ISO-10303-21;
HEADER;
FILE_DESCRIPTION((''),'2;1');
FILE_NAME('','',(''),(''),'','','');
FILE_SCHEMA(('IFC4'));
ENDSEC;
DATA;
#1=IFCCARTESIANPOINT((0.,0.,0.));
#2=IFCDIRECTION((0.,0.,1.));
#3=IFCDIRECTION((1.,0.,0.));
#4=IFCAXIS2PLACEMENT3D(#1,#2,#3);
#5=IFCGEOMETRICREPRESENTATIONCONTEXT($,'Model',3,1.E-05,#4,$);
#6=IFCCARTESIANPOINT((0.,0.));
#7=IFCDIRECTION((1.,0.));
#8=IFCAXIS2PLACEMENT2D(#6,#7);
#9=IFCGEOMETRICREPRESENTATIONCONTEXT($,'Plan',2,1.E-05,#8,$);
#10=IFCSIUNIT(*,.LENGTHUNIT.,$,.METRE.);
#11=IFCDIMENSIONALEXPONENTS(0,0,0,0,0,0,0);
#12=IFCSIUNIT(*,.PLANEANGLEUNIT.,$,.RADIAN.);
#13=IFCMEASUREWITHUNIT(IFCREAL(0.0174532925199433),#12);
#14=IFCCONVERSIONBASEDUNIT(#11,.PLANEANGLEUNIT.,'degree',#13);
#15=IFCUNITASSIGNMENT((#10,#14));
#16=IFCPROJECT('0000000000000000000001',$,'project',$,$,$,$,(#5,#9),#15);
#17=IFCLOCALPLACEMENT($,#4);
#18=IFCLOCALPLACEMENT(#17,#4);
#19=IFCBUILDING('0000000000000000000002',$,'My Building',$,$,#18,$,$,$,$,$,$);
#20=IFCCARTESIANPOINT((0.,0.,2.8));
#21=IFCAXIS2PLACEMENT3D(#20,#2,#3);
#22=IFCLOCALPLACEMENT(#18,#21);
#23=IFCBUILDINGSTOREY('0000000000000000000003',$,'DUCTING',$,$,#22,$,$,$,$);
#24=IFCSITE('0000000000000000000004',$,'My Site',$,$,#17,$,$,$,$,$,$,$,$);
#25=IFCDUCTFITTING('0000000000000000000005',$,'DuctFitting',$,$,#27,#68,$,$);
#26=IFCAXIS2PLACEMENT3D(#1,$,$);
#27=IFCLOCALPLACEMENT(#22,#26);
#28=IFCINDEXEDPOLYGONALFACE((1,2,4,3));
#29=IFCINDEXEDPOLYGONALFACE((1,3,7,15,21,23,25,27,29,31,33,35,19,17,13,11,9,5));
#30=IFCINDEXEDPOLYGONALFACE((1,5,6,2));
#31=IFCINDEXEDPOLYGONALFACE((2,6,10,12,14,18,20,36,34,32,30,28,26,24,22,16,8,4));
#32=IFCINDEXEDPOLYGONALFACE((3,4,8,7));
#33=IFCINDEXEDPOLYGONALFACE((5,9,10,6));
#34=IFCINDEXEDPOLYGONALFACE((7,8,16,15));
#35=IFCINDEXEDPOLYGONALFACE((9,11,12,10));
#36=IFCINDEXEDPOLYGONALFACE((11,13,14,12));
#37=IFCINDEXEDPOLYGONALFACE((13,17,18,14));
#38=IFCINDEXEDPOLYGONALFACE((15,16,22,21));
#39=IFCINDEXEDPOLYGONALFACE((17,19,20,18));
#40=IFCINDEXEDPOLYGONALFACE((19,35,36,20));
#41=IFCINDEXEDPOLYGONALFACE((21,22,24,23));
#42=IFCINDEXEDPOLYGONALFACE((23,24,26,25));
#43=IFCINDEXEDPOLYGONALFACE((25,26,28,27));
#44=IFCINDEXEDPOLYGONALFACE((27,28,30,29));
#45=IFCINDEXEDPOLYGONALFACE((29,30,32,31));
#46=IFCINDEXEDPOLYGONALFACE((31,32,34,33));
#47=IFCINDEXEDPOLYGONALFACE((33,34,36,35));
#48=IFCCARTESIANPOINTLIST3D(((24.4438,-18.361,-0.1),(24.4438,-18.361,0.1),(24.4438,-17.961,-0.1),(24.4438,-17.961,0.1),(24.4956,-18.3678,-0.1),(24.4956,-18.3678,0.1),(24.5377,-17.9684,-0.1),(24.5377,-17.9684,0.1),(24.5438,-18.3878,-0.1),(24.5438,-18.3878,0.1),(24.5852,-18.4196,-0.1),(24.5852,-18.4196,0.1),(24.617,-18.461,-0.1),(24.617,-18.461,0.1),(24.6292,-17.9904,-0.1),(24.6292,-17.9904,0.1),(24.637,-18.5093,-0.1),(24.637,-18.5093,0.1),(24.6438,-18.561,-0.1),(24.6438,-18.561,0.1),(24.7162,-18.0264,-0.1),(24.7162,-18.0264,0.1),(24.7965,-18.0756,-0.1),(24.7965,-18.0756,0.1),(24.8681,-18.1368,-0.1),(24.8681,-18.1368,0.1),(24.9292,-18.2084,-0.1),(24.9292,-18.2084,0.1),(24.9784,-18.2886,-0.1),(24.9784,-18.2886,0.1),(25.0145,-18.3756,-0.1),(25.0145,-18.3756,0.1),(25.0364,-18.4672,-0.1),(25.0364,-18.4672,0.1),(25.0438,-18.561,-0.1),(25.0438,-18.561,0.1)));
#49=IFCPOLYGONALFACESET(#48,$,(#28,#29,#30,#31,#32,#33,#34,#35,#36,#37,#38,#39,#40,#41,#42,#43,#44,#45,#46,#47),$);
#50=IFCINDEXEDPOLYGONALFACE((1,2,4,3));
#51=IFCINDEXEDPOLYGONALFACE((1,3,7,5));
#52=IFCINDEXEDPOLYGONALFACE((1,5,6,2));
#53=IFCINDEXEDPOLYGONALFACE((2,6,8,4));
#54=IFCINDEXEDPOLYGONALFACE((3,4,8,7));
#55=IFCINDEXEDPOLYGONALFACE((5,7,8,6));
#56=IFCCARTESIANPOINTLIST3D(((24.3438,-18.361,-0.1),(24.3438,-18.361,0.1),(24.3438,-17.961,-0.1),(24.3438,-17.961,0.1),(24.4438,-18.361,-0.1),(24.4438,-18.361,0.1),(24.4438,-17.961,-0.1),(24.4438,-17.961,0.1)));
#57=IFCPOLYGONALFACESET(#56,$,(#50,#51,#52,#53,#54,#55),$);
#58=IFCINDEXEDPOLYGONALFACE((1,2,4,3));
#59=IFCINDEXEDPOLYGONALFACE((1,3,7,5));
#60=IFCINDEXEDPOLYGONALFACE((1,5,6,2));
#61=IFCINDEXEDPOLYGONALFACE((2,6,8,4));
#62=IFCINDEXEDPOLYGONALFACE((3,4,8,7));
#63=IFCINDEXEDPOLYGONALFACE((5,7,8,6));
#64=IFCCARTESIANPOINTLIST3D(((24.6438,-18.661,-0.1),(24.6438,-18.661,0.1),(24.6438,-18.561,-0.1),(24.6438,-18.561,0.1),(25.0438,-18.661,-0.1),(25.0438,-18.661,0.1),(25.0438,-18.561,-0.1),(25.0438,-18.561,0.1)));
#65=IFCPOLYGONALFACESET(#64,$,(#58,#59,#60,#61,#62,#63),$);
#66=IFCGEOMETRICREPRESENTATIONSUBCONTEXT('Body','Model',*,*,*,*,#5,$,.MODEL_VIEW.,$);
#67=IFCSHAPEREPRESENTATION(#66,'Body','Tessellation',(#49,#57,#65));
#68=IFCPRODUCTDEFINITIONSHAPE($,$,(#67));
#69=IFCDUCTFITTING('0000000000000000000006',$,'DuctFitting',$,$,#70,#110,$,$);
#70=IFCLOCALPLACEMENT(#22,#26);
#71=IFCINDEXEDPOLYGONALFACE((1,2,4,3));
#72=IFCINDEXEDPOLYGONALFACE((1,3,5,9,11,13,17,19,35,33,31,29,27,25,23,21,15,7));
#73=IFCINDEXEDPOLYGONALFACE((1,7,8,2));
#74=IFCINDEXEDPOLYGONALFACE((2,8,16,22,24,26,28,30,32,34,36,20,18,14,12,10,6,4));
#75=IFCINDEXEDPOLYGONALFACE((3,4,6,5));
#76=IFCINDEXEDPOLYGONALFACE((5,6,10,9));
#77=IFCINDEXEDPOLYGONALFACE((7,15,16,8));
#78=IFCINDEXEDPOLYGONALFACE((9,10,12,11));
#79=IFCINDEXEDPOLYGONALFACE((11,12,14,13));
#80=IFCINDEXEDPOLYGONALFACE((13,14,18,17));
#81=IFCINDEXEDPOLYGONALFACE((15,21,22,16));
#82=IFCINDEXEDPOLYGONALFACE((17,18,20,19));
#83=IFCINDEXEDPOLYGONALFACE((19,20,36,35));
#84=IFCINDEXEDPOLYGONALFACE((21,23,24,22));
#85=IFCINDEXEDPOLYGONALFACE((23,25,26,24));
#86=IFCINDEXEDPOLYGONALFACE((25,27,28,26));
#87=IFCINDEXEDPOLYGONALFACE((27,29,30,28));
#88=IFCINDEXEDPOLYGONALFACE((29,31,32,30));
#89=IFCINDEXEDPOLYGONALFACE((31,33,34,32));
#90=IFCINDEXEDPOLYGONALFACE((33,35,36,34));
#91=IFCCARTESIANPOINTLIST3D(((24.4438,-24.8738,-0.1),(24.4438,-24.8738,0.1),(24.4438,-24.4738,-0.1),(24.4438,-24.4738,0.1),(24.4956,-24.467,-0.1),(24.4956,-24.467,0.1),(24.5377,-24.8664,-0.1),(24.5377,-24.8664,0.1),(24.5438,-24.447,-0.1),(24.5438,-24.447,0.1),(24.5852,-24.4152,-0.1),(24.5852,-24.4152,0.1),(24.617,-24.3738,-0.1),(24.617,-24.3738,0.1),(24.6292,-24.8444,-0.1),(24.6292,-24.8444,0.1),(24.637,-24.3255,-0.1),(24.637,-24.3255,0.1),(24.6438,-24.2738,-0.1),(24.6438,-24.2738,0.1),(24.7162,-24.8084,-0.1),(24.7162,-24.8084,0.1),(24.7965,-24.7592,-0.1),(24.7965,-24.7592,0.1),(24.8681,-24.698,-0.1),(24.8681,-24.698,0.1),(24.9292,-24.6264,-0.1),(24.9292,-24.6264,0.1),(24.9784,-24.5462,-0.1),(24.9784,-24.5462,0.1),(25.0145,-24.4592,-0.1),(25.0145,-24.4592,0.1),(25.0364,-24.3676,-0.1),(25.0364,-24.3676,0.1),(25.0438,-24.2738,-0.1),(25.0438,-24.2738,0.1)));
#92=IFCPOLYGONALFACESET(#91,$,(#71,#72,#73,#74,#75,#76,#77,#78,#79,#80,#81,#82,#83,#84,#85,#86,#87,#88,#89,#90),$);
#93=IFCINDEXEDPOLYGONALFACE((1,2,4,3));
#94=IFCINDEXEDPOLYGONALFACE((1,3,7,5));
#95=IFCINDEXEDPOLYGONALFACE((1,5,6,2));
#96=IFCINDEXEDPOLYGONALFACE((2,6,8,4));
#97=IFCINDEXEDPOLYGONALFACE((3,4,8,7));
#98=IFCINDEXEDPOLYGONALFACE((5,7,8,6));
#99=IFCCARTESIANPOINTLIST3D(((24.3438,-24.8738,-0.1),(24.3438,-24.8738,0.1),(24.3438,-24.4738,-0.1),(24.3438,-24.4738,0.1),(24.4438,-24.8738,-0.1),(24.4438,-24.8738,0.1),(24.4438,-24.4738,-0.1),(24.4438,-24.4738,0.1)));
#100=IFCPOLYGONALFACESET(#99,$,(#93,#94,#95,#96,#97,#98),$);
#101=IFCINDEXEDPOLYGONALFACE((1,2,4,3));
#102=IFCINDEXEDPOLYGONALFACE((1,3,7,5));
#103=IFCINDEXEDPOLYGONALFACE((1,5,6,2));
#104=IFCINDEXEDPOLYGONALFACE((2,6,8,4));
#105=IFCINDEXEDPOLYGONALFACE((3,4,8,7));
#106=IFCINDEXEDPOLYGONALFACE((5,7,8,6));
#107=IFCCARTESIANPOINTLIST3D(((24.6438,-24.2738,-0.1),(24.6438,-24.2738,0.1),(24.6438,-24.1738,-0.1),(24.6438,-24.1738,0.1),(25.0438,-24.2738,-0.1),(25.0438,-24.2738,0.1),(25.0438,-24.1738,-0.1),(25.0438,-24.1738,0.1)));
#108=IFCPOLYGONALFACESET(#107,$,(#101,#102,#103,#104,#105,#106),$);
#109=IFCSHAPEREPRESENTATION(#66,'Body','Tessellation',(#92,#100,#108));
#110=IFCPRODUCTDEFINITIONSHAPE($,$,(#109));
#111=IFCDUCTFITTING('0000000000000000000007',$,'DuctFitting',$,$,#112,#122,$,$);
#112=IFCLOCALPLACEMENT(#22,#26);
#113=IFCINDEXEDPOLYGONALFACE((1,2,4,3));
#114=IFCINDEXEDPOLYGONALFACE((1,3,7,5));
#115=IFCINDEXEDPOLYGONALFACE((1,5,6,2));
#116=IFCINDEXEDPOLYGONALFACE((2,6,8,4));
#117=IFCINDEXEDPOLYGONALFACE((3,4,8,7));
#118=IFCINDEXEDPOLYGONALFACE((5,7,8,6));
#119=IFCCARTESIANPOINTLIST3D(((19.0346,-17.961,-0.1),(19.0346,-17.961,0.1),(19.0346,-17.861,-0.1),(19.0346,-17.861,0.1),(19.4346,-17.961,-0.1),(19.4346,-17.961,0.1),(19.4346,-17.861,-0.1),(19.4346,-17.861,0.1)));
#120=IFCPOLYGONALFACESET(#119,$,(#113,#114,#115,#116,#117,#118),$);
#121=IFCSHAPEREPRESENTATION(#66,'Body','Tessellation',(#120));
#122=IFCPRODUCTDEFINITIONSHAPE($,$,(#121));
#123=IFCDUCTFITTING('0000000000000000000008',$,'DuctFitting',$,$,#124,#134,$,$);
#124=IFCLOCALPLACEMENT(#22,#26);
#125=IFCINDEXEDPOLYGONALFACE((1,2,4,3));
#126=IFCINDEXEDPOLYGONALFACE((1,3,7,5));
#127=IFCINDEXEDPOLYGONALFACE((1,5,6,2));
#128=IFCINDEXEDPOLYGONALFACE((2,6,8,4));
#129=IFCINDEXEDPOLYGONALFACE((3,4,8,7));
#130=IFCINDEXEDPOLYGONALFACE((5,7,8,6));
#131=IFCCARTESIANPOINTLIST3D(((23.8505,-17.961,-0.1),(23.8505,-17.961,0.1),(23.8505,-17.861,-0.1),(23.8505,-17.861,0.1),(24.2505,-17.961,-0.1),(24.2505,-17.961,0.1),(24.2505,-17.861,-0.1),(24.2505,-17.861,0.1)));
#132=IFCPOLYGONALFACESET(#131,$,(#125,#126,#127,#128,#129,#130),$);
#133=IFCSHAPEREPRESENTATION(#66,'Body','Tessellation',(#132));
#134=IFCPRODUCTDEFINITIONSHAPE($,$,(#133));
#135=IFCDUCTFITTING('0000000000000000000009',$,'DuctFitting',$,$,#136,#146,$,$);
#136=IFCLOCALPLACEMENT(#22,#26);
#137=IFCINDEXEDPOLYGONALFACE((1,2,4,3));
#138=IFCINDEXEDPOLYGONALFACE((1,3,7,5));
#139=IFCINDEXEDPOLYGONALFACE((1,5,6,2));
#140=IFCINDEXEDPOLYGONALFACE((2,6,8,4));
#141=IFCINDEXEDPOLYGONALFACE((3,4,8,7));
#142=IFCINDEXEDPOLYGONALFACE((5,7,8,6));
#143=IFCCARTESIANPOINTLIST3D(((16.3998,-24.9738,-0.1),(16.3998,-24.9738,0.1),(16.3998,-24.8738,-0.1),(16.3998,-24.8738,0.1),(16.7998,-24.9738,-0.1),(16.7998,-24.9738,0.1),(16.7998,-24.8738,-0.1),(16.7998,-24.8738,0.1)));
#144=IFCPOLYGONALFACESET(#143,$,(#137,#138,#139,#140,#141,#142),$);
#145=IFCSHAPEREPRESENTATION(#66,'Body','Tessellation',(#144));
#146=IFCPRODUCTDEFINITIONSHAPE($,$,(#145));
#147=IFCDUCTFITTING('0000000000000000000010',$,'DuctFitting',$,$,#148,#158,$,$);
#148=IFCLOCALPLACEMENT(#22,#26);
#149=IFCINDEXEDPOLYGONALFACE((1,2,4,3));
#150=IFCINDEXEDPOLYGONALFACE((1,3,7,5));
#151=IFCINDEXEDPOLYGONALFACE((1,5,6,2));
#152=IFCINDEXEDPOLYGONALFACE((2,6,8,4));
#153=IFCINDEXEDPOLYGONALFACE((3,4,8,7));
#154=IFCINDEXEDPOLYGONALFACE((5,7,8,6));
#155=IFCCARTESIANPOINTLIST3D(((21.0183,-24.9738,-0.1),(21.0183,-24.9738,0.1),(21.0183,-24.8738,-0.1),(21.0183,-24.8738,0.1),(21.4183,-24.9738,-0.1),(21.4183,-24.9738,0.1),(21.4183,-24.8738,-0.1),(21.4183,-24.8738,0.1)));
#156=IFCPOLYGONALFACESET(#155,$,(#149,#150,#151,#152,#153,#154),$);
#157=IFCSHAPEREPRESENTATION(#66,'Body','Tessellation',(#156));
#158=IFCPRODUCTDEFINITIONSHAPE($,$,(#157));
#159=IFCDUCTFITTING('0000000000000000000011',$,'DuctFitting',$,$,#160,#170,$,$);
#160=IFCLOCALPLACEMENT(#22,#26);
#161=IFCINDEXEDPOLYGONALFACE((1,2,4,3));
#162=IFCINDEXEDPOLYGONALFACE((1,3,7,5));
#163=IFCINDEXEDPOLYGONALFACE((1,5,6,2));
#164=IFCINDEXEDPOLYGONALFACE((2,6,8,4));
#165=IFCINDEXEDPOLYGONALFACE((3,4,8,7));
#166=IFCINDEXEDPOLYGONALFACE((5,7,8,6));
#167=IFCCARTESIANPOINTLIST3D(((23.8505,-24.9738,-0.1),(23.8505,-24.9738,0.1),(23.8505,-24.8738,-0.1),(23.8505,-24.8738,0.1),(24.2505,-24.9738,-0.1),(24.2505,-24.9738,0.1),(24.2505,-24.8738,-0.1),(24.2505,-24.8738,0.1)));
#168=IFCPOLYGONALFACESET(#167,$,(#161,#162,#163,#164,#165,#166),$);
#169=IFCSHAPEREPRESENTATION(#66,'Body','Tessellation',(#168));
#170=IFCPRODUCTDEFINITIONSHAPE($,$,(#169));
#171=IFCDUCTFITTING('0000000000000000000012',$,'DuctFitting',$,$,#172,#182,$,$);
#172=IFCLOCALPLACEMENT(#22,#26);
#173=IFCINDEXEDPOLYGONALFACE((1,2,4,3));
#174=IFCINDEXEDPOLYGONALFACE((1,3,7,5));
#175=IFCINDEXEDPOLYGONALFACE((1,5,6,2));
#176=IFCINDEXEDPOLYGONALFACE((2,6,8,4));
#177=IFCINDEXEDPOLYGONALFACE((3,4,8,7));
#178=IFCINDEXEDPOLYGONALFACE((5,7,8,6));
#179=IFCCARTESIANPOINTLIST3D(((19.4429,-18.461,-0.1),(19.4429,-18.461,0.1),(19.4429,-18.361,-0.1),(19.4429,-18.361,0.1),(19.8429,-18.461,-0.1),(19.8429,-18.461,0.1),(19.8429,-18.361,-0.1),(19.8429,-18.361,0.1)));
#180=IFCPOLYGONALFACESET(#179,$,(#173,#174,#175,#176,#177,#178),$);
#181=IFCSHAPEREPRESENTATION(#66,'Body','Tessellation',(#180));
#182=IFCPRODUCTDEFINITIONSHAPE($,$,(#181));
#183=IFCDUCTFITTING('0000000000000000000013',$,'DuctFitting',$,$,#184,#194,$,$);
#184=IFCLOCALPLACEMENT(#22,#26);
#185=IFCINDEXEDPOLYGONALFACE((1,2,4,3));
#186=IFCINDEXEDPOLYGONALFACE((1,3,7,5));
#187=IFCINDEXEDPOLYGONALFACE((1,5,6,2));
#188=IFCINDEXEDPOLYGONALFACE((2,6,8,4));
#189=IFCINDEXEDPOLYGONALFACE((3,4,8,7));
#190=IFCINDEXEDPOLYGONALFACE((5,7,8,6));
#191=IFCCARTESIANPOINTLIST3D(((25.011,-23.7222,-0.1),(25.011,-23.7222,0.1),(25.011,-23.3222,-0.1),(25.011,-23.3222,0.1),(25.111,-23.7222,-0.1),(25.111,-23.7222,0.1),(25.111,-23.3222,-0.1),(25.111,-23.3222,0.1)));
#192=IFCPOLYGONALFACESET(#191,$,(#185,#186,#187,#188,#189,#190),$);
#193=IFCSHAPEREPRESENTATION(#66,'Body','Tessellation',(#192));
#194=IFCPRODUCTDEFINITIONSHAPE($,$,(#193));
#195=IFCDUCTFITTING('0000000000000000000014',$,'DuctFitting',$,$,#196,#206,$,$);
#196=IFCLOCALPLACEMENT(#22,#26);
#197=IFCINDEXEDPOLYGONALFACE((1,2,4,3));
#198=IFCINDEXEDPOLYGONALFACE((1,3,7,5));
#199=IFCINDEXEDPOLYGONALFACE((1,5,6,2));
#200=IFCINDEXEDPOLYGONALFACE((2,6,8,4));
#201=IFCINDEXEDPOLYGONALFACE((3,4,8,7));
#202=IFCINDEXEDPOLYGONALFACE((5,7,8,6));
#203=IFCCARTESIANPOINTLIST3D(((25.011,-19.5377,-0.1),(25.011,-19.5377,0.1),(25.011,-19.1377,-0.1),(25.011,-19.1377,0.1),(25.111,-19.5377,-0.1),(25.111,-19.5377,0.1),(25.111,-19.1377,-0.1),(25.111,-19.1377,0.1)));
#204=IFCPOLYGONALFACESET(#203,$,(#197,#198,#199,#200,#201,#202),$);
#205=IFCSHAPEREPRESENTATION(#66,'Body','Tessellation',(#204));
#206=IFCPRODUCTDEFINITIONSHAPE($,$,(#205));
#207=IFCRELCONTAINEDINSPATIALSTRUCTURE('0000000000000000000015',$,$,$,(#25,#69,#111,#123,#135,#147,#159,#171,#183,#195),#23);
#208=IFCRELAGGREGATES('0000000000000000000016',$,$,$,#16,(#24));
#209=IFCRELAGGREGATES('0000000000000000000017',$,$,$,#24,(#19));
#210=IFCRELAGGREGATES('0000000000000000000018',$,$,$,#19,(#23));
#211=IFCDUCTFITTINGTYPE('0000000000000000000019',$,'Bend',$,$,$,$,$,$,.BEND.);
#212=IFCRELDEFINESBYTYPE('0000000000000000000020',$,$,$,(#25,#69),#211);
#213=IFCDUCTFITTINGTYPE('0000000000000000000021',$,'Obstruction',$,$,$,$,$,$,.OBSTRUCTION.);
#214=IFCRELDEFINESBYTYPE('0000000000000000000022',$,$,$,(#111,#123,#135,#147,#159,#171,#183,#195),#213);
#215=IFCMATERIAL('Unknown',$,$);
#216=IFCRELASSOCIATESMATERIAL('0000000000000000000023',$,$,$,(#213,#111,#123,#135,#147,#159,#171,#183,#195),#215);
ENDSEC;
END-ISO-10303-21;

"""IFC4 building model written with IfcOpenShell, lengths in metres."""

from ifc_helpers import new_model, entity, si_unit, converted_unit, frame, origin_with_axes, origin_2d_with_axis, place, context, subcontext, project, spatial, line, arc, indexed_curve, rectangle, outline, extrude, source, transform, mapped, material, material_profile, profile_set, profile_usage, type_object, type_shapes, element, save


model = new_model("IFC4")

# Units and contexts
model_context = context("Model", 3, precision=1e-05, world=origin_with_axes())
plan_context = context("Plan", 2, precision=1e-05, world=origin_2d_with_axis())
body_context = subcontext(model_context, "Body", "Model", "MODEL_VIEW")
ifc_project = project(units=[si_unit("LENGTHUNIT", "METRE"), converted_unit("PLANEANGLEUNIT", "degree", entity("IfcReal", 0.0174532925199433), si_unit("PLANEANGLEUNIT", "RADIAN"), dimensions=[0, 0, 0, 0, 0, 0, 0])], contexts=[model_context, plan_context])

# Site, building, storey
site_placement = place(None, origin_with_axes())
site = spatial("IfcSite", under=ifc_project, at=site_placement, Name="My Site")
building_placement = place(site_placement, origin_with_axes())
building = spatial("IfcBuilding", under=site, at=building_placement, Name="My Building")
storey_placement = place(building_placement, frame((0.0, 0.0, 2.8), z_axis=(0.0, 0.0, 1.0), x_axis=(1.0, 0.0, 0.0)))
storey = spatial("IfcBuildingStorey", under=building, at=storey_placement, Name="DUCTING")

# Shared definitions
ifc_material = material(Name="Unknown")

# Duct fittings
duct_fitting_type_1 = type_object("IfcDuctFittingType", Name="Bend", PredefinedType="BEND")
shared_shape = source(origin_with_axes(), body_context, "Body", "SweptSolid", [
    extrude(outline(indexed_curve([(-0.2, 0.0), (-0.2586, -0.1414), (-0.4, -0.2), (-0.4, -0.6), (0.0243, -0.4243), (0.2, 0.0)], segments=[arc(1, 2, 3), line(3, 4), arc(4, 5, 6), line(6, 1)])), frame((0.0, -0.1, -0.1), z_axis=(0.0, -1.0, 0.0), x_axis=(1.0, 0.0, 0.0)), (0.0, 0.0, -1.0), 0.2),
    extrude(rectangle(XDim=0.4, YDim=0.2), origin_with_axes(), (0.0, 0.0, -1.0), 0.1),
    extrude(rectangle(XDim=0.4, YDim=0.2), frame((-0.4, 0.0, -0.5), z_axis=(-1.0, 0.0, 0.0), x_axis=(0.0, 0.0, -1.0)), (0.0, 0.0, 1.0), 0.1),
])
type_shapes(duct_fitting_type_1, [shared_shape])
for number, where, z_axis, x_axis, name in (
    (1, (24.3438, -18.161, 0.0), (-1.0, 0.0, 0.0), (0.0, 1.0, 0.0), "DuctFitting"),
    (2, (24.3438, -24.6738, 0.0), (-1.0, 0.0, 0.0), (0.0, -1.0, 0.0), "DuctFitting"),
):
    element("IfcDuctFitting", number, at=place(storey_placement, frame(where, z_axis=z_axis, x_axis=x_axis)), inside=storey, type_object=duct_fitting_type_1, Name=name, context=body_context, shape_type="MappedRepresentation", body=[
        mapped(shared_shape, transform((0.0, 0.0, 0.0), x_axis=(1.0, 0.0, 0.0), y_axis=(0.0, 1.0, 0.0), z_axis=(0.0, 0.0, 1.0), scale=1.0)),
    ])
ifc_material_profile_1 = material_profile(ifc_material, rectangle(XDim=0.4, YDim=0.2))
ifc_profile_set_1 = profile_set([ifc_material_profile_1])
ifc_profile_usage_1 = profile_usage(ifc_profile_set_1, cardinal=5)
duct_fitting_type_2 = type_object("IfcDuctFittingType", Name="Obstruction", PredefinedType="OBSTRUCTION", material=ifc_profile_set_1)
duct_fitting_1_placement = place(storey_placement, frame((19.2346, -17.961, 0.0), z_axis=(0.0, 1.0, 0.0), x_axis=(-1.0, 0.0, 0.0)))
element("IfcDuctFitting", 3, at=duct_fitting_1_placement, inside=storey, type_object=duct_fitting_type_2, material=ifc_profile_usage_1, Name="DuctFitting", context=body_context, shape_type="SweptSolid", body=[
    extrude(rectangle(XDim=0.4, YDim=0.2), origin_with_axes(), (0.0, 0.0, 1.0), 0.1),
])
ifc_profile_usage_2 = profile_usage(ifc_profile_set_1, cardinal=5)
duct_fitting_2_placement = place(storey_placement, frame((24.0505, -17.961, 0.0), z_axis=(0.0, 1.0, 0.0), x_axis=(-1.0, 0.0, 0.0)))
element("IfcDuctFitting", 4, at=duct_fitting_2_placement, inside=storey, type_object=duct_fitting_type_2, material=ifc_profile_usage_2, Name="DuctFitting", context=body_context, shape_type="SweptSolid", body=[
    extrude(rectangle(XDim=0.4, YDim=0.2), origin_with_axes(), (0.0, 0.0, 1.0), 0.1),
])
ifc_profile_usage_3 = profile_usage(ifc_profile_set_1, cardinal=5)
duct_fitting_3_placement = place(storey_placement, frame((16.5998, -24.8738, 0.0), z_axis=(0.0, -1.0, 0.0), x_axis=(1.0, 0.0, 0.0)))
element("IfcDuctFitting", 5, at=duct_fitting_3_placement, inside=storey, type_object=duct_fitting_type_2, material=ifc_profile_usage_3, Name="DuctFitting", context=body_context, shape_type="SweptSolid", body=[
    extrude(rectangle(XDim=0.4, YDim=0.2), origin_with_axes(), (0.0, 0.0, 1.0), 0.1),
])
ifc_profile_usage_4 = profile_usage(ifc_profile_set_1, cardinal=5)
duct_fitting_4_placement = place(storey_placement, frame((21.2183, -24.8738, 0.0), z_axis=(0.0, -1.0, 0.0), x_axis=(1.0, 0.0, 0.0)))
element("IfcDuctFitting", 6, at=duct_fitting_4_placement, inside=storey, type_object=duct_fitting_type_2, material=ifc_profile_usage_4, Name="DuctFitting", context=body_context, shape_type="SweptSolid", body=[
    extrude(rectangle(XDim=0.4, YDim=0.2), origin_with_axes(), (0.0, 0.0, 1.0), 0.1),
])
ifc_profile_usage_5 = profile_usage(ifc_profile_set_1, cardinal=5)
duct_fitting_5_placement = place(storey_placement, frame((24.0505, -24.8738, 0.0), z_axis=(0.0, -1.0, 0.0), x_axis=(1.0, 0.0, 0.0)))
element("IfcDuctFitting", 7, at=duct_fitting_5_placement, inside=storey, type_object=duct_fitting_type_2, material=ifc_profile_usage_5, Name="DuctFitting", context=body_context, shape_type="SweptSolid", body=[
    extrude(rectangle(XDim=0.4, YDim=0.2), origin_with_axes(), (0.0, 0.0, 1.0), 0.1),
])
ifc_profile_usage_6 = profile_usage(ifc_profile_set_1, cardinal=5)
duct_fitting_6_placement = place(storey_placement, frame((19.6429, -18.361, 0.0), z_axis=(0.0, -1.0, 0.0), x_axis=(1.0, 0.0, 0.0)))
element("IfcDuctFitting", 8, at=duct_fitting_6_placement, inside=storey, type_object=duct_fitting_type_2, material=ifc_profile_usage_6, Name="DuctFitting", context=body_context, shape_type="SweptSolid", body=[
    extrude(rectangle(XDim=0.4, YDim=0.2), origin_with_axes(), (0.0, 0.0, 1.0), 0.1),
])
ifc_profile_usage_7 = profile_usage(ifc_profile_set_1, cardinal=5)
duct_fitting_7_placement = place(storey_placement, frame((25.011, -23.5222, 0.0), z_axis=(1.0, -0.000001, 0.000001), x_axis=(0.000001, 1.0, 0.0)))
element("IfcDuctFitting", 9, at=duct_fitting_7_placement, inside=storey, type_object=duct_fitting_type_2, material=ifc_profile_usage_7, Name="DuctFitting", context=body_context, shape_type="SweptSolid", body=[
    extrude(rectangle(XDim=0.4, YDim=0.2), origin_with_axes(), (0.0, 0.0, 1.0), 0.1),
])
ifc_profile_usage_8 = profile_usage(ifc_profile_set_1, cardinal=5)
duct_fitting_8_placement = place(storey_placement, frame((25.011, -19.3377, 0.0), z_axis=(1.0, -0.000001, 0.000001), x_axis=(0.000001, 1.0, 0.0)))
element("IfcDuctFitting", 10, at=duct_fitting_8_placement, inside=storey, type_object=duct_fitting_type_2, material=ifc_profile_usage_8, Name="DuctFitting", context=body_context, shape_type="SweptSolid", body=[
    extrude(rectangle(XDim=0.4, YDim=0.2), origin_with_axes(), (0.0, 0.0, 1.0), 0.1),
])

save(model, "model.ifc")
